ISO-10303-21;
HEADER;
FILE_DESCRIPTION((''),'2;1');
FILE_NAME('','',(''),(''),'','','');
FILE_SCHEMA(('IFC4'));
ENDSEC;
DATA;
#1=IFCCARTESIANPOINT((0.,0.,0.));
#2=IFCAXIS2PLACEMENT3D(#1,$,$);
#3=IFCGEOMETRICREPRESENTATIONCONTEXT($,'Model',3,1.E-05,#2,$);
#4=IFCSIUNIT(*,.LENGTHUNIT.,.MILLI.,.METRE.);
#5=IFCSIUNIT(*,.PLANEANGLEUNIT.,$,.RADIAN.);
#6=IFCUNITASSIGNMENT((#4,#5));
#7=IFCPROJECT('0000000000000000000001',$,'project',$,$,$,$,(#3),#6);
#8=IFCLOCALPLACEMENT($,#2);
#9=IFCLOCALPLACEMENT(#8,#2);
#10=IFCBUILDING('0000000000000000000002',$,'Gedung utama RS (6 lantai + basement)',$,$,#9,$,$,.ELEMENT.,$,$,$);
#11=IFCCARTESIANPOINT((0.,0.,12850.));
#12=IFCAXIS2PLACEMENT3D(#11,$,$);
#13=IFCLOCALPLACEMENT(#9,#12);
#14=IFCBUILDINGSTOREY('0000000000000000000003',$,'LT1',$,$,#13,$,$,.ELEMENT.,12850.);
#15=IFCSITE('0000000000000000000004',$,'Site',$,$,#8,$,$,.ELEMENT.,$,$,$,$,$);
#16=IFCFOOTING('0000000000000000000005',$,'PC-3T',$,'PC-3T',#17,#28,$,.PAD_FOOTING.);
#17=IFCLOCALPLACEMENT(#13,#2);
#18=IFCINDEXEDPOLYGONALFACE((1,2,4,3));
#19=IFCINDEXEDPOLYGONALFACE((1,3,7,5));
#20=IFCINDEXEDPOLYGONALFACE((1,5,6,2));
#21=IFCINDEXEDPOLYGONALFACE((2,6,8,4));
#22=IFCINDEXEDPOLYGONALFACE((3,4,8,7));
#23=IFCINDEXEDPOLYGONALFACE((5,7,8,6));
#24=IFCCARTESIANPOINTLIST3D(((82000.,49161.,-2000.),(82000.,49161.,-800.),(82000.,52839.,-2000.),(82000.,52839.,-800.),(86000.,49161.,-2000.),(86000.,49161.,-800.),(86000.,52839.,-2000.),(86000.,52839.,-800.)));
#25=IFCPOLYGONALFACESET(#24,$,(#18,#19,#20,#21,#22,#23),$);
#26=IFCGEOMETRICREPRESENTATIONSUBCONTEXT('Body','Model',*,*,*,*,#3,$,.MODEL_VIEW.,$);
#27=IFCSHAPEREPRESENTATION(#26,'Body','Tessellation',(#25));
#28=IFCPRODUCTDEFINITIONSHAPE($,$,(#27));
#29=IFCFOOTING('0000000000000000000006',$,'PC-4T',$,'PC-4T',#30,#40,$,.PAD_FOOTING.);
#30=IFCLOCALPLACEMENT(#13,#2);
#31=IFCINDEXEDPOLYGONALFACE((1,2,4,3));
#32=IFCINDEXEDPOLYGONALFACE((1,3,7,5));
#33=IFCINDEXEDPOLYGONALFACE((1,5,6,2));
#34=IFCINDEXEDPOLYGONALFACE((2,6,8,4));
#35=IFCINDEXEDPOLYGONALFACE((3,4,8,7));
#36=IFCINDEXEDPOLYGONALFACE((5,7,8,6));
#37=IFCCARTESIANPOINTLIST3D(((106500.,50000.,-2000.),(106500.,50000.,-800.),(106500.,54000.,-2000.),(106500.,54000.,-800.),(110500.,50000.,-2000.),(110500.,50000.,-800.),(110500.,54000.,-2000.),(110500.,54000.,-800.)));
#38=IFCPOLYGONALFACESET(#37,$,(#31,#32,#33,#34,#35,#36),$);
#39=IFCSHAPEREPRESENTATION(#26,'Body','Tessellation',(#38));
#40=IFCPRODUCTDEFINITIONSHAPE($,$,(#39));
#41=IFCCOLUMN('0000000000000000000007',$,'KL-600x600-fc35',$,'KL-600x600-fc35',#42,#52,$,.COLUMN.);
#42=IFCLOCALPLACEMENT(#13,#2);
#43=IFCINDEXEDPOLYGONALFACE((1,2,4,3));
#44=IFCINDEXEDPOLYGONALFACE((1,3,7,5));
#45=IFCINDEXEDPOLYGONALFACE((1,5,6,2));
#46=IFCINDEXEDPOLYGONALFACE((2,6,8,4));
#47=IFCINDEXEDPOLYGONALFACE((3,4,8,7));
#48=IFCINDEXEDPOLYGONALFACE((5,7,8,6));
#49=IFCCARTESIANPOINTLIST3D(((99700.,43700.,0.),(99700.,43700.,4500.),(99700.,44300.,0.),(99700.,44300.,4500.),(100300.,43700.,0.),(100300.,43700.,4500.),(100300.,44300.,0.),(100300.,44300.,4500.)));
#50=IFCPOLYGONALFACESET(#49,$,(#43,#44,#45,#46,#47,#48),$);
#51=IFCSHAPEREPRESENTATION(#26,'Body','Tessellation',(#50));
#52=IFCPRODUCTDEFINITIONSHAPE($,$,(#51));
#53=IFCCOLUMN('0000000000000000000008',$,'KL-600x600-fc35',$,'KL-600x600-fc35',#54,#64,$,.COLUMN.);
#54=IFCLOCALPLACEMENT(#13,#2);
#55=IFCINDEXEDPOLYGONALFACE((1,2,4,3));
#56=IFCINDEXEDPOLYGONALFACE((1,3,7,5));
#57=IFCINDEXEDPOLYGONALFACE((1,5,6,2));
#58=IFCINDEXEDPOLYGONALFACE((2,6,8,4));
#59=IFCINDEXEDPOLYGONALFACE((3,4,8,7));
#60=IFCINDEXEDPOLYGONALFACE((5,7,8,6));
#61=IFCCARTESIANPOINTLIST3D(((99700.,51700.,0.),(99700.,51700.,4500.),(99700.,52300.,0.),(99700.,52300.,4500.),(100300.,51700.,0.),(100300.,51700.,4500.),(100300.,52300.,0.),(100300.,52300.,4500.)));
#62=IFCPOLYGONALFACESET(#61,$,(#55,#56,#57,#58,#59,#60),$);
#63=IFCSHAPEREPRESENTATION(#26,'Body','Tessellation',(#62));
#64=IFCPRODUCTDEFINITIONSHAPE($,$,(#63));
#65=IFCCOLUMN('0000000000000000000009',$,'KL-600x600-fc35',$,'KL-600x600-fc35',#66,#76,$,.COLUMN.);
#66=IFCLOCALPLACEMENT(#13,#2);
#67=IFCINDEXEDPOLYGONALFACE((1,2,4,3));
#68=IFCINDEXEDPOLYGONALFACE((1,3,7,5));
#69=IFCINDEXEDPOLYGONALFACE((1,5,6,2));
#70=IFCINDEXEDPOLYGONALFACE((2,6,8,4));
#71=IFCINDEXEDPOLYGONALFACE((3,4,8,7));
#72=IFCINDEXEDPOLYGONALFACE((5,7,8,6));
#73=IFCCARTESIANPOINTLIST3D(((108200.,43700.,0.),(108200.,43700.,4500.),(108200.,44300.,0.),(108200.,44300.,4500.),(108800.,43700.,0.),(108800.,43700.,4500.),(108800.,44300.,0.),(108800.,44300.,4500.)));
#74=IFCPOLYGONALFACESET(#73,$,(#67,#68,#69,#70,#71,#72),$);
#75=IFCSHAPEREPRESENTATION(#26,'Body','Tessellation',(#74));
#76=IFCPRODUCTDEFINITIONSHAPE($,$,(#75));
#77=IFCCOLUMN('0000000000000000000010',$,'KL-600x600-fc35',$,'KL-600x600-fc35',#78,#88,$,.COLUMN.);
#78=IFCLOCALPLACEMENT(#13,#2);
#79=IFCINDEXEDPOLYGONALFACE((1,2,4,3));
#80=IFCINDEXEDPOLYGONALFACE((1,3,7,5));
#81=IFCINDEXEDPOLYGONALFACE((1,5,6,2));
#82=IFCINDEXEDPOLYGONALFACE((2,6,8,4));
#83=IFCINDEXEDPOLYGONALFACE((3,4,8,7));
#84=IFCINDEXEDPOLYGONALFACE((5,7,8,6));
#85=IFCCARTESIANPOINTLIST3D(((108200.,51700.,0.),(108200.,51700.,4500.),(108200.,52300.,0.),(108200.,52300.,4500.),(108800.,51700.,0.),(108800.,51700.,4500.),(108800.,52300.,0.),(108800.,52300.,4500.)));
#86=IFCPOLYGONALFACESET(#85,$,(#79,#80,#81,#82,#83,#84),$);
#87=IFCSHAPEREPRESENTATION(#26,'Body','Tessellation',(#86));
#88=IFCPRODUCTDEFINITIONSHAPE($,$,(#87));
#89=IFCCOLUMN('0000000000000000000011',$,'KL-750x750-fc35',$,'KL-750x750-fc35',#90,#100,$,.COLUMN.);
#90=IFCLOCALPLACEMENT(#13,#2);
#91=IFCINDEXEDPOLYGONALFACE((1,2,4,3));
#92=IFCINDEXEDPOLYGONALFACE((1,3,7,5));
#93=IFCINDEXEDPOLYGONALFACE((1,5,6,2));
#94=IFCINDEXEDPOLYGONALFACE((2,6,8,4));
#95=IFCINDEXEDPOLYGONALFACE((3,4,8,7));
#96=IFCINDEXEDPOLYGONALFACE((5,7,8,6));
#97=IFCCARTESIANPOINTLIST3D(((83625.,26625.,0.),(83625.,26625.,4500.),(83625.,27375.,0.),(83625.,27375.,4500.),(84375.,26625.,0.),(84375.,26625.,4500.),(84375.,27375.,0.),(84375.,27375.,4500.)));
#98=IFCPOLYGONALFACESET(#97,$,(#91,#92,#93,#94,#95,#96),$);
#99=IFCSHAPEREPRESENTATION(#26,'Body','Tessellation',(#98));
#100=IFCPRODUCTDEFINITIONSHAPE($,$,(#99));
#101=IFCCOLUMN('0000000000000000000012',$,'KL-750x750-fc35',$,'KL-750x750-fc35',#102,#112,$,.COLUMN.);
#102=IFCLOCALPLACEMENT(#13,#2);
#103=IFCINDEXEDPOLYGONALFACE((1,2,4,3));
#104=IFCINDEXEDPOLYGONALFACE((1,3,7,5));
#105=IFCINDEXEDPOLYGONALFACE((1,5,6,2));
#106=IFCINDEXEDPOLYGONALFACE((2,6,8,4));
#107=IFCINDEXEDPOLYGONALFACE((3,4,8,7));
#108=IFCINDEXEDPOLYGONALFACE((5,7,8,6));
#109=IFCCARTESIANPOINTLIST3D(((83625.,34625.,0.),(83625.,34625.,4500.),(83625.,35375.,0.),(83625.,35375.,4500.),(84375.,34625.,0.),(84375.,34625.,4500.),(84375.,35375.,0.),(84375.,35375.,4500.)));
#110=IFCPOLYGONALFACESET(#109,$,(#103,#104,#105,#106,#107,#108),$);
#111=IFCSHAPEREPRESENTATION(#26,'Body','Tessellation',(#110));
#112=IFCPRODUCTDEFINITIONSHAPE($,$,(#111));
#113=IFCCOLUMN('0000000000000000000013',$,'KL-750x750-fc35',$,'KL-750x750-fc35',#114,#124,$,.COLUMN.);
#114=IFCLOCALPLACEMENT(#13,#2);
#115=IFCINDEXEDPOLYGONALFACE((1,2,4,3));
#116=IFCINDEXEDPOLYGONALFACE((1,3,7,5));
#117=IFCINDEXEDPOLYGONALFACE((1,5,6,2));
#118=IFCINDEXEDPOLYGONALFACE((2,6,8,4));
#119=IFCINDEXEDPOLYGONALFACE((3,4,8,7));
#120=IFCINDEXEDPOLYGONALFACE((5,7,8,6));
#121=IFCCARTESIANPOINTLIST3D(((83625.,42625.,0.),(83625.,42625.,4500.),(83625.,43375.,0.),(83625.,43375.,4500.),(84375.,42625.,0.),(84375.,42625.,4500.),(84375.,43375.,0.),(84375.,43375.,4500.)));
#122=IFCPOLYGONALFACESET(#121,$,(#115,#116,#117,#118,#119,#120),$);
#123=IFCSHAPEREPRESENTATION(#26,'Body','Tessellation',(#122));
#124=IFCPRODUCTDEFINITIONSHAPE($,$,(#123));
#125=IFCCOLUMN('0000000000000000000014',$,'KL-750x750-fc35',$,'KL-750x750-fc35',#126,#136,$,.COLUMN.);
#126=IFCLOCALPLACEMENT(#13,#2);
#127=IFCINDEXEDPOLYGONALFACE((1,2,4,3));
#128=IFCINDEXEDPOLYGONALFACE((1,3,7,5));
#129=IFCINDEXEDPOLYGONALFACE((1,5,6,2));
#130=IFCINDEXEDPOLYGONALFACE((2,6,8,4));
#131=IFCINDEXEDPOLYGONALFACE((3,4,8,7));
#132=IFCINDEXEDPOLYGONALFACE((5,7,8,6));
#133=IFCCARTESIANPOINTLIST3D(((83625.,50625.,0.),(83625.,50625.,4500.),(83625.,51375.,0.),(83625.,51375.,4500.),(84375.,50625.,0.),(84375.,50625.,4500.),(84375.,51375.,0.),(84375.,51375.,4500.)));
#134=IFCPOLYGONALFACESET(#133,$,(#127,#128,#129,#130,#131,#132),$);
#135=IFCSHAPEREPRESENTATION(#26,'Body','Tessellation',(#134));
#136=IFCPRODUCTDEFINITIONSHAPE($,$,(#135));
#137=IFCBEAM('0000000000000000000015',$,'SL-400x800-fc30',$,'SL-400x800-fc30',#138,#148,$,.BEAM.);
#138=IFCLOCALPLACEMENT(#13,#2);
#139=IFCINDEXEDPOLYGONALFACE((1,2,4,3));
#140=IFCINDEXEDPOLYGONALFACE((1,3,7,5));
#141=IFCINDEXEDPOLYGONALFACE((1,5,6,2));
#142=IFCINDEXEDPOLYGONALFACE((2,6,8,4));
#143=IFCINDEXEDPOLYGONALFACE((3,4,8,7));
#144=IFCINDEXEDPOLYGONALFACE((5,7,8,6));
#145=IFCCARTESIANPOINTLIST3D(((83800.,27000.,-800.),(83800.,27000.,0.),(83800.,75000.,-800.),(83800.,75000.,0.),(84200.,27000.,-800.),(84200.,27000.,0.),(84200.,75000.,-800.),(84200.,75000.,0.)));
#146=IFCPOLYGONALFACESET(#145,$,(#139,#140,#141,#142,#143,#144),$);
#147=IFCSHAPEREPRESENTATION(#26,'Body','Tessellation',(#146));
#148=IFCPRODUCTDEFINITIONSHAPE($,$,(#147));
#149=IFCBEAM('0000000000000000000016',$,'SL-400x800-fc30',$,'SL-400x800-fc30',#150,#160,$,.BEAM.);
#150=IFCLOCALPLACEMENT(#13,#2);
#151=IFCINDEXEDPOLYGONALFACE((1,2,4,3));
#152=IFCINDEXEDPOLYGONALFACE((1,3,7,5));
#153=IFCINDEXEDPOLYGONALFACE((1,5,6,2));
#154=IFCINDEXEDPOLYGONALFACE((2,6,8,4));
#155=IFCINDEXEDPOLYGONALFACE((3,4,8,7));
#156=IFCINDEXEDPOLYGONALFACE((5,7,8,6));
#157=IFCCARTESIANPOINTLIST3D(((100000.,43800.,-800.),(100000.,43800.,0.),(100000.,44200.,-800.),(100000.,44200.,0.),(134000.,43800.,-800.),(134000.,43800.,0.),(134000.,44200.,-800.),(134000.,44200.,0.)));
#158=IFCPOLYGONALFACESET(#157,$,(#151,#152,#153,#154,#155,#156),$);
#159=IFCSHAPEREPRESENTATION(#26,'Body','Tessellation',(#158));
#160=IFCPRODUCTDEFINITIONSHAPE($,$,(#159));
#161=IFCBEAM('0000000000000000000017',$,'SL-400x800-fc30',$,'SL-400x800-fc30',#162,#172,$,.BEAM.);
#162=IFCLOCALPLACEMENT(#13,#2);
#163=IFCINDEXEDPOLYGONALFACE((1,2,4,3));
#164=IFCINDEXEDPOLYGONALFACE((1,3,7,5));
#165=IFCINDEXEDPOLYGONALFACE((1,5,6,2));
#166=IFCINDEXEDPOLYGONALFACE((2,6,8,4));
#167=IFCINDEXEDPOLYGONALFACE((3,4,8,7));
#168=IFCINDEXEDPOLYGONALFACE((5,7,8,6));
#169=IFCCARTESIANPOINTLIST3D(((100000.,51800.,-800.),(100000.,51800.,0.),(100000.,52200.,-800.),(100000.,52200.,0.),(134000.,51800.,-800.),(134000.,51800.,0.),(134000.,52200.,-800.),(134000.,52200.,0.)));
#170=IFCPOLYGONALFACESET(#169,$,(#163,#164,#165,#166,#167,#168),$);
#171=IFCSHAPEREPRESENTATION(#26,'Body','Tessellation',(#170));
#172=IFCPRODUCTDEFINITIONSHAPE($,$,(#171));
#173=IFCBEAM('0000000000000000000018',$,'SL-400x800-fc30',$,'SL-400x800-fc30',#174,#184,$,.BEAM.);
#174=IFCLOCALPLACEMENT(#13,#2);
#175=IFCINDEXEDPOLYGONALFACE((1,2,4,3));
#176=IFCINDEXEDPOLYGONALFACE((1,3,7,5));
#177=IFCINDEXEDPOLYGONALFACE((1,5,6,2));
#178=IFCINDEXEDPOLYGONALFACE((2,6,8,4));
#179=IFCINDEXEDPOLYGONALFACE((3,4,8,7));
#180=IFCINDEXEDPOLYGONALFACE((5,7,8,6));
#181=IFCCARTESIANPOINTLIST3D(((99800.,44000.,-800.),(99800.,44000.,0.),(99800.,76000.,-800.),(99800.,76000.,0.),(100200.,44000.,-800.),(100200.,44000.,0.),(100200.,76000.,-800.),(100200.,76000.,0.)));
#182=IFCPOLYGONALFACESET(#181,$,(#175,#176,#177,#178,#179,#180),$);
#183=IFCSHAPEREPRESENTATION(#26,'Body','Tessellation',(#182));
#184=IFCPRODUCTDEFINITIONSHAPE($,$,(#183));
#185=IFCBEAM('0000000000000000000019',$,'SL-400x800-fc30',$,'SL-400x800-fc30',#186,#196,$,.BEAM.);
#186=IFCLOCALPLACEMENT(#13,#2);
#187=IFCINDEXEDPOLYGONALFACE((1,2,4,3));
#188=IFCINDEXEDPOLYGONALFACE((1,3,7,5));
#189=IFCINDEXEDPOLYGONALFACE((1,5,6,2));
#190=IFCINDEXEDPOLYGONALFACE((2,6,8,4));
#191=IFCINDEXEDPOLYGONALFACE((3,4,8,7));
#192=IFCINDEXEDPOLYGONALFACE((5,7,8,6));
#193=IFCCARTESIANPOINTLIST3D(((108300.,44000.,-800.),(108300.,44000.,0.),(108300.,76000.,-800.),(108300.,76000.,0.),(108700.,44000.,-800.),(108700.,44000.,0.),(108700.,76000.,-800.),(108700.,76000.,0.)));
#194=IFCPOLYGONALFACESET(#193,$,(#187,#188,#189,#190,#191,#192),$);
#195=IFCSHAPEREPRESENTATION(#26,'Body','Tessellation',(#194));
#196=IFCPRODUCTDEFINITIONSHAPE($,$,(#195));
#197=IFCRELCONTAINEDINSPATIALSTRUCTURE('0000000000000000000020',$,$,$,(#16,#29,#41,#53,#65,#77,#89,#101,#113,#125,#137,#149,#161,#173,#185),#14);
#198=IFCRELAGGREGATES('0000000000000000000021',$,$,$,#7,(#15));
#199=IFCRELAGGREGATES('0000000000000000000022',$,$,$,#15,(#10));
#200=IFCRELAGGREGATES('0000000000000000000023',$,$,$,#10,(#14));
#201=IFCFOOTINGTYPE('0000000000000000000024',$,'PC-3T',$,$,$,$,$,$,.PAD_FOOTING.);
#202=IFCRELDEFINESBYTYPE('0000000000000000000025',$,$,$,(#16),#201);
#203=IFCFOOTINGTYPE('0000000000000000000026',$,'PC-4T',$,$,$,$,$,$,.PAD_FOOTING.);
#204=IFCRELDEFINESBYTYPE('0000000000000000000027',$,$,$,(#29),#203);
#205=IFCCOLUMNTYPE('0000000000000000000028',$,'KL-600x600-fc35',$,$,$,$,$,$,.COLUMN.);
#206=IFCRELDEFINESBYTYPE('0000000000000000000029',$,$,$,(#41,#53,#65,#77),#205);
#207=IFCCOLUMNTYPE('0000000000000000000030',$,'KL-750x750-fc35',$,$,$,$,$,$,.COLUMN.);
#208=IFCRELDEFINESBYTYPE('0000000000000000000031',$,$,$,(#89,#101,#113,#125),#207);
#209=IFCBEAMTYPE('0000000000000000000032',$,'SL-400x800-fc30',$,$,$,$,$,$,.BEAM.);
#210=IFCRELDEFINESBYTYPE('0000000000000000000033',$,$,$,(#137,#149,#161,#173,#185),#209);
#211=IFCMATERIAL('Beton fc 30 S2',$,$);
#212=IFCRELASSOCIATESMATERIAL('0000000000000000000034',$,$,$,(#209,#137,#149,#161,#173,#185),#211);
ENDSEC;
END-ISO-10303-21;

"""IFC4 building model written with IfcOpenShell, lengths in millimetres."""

from ifc_helpers import new_model, si_unit, frame, origin, origin_2d, place, context, subcontext, project, spatial, rectangle, extrude, material, material_profile, profile_set, profile_usage, type_object, element, save


model = new_model("IFC4")

# Units and contexts
model_context = context("Model", 3, precision=1e-05, world=origin())
body_context = subcontext(model_context, "Body", "Model", "MODEL_VIEW")
ifc_project = project(units=[si_unit("LENGTHUNIT", "METRE", prefix="MILLI"), si_unit("PLANEANGLEUNIT", "RADIAN")], contexts=[model_context])

# Site, building, storey
site_placement = place(None, origin())
site = spatial("IfcSite", under=ifc_project, at=site_placement, Name="Site", CompositionType="ELEMENT")
building_placement = place(site_placement, origin())
building = spatial("IfcBuilding", under=site, at=building_placement, Name="Gedung utama RS (6 lantai + basement)", CompositionType="ELEMENT")
storey_placement = place(building_placement, frame((0.0, 0.0, 12850.0)))
storey = spatial("IfcBuildingStorey", under=building, at=storey_placement, Name="LT1", CompositionType="ELEMENT", Elevation=12850.0)

# Footings
ifc_material_profile_1 = material_profile(None, rectangle(XDim=4000.0, YDim=3678.0, at=origin_2d()), Name="PC-3T")
ifc_profile_set_1 = profile_set([ifc_material_profile_1], Name="PC-3T")
ifc_profile_usage_1 = profile_usage(ifc_profile_set_1, cardinal=5)
footing_type_1 = type_object("IfcFootingType", Name="PC-3T", PredefinedType="PAD_FOOTING", material=ifc_profile_set_1)
for number, where, z_axis, x_axis, name in (
    (1, (84000.0, 51000.0, -2000.0), (0.0, 0.0, 1.0), (1.0, 0.0, 0.0), "PC-3T"),
):
    element("IfcFooting", number, at=place(storey_placement, frame(where, z_axis=z_axis, x_axis=x_axis)), inside=storey, type_object=footing_type_1, material=ifc_profile_usage_1, Name=name, ObjectType="PC-3T", PredefinedType="PAD_FOOTING", context=body_context, shape_type="SweptSolid", body=[
        extrude(rectangle(XDim=4000.0, YDim=3678.0, at=origin_2d()), origin(), (0.0, 0.0, 1.0), 1200.0),
    ])
ifc_material_profile_2 = material_profile(None, rectangle(XDim=4000.0, YDim=4000.0, at=origin_2d()), Name="PC-4T")
ifc_profile_set_2 = profile_set([ifc_material_profile_2], Name="PC-4T")
ifc_profile_usage_2 = profile_usage(ifc_profile_set_2, cardinal=5)
footing_type_2 = type_object("IfcFootingType", Name="PC-4T", PredefinedType="PAD_FOOTING", material=ifc_profile_set_2)
footing_placement = place(storey_placement, frame((108500.0, 52000.0, -2000.0), z_axis=(0.0, 0.0, 1.0), x_axis=(1.0, 0.0, 0.0)))
element("IfcFooting", 2, at=footing_placement, inside=storey, type_object=footing_type_2, material=ifc_profile_usage_2, Name="PC-4T", ObjectType="PC-4T", PredefinedType="PAD_FOOTING", context=body_context, shape_type="SweptSolid", body=[
    extrude(rectangle(XDim=4000.0, YDim=4000.0, at=origin_2d()), origin(), (0.0, 0.0, 1.0), 1200.0),
])

# Columns
ifc_material_profile_3 = material_profile(None, rectangle(XDim=600.0, YDim=600.0, at=origin_2d()), Name="KL-600x600-fc35")
ifc_profile_set_3 = profile_set([ifc_material_profile_3], Name="KL-600x600-fc35")
ifc_profile_usage_3 = profile_usage(ifc_profile_set_3, cardinal=5)
column_type_1 = type_object("IfcColumnType", Name="KL-600x600-fc35", PredefinedType="COLUMN", material=ifc_profile_set_3)
for number, where, z_axis, x_axis, name in (
    (3, (100000.0, 44000.0, 0.0), (0.0, 0.0, 1.0), (1.0, 0.0, 0.0), "KL-600x600-fc35"),
    (4, (100000.0, 52000.0, 0.0), (0.0, 0.0, 1.0), (1.0, 0.0, 0.0), "KL-600x600-fc35"),
    (5, (108500.0, 44000.0, 0.0), (0.0, 0.0, 1.0), (1.0, 0.0, 0.0), "KL-600x600-fc35"),
    (6, (108500.0, 52000.0, 0.0), (0.0, 0.0, 1.0), (1.0, 0.0, 0.0), "KL-600x600-fc35"),
):
    element("IfcColumn", number, at=place(storey_placement, frame(where, z_axis=z_axis, x_axis=x_axis)), inside=storey, type_object=column_type_1, material=ifc_profile_usage_3, Name=name, ObjectType="KL-600x600-fc35", PredefinedType="COLUMN", context=body_context, shape_type="SweptSolid", body=[
        extrude(rectangle(XDim=600.0, YDim=600.0, at=origin_2d()), origin(), (0.0, 0.0, 1.0), 4500.0),
    ])
ifc_material_profile_4 = material_profile(None, rectangle(XDim=750.0, YDim=750.0, at=origin_2d()), Name="KL-750x750-fc35")
ifc_profile_set_4 = profile_set([ifc_material_profile_4], Name="KL-750x750-fc35")
ifc_profile_usage_4 = profile_usage(ifc_profile_set_4, cardinal=5)
column_type_2 = type_object("IfcColumnType", Name="KL-750x750-fc35", PredefinedType="COLUMN", material=ifc_profile_set_4)
for number, where, z_axis, x_axis, name in (
    (7, (84000.0, 27000.0, 0.0), (0.0, 0.0, 1.0), (1.0, 0.0, 0.0), "KL-750x750-fc35"),
    (8, (84000.0, 35000.0, 0.0), (0.0, 0.0, 1.0), (1.0, 0.0, 0.0), "KL-750x750-fc35"),
    (9, (84000.0, 43000.0, 0.0), (0.0, 0.0, 1.0), (1.0, 0.0, 0.0), "KL-750x750-fc35"),
    (10, (84000.0, 51000.0, 0.0), (0.0, 0.0, 1.0), (1.0, 0.0, 0.0), "KL-750x750-fc35"),
):
    element("IfcColumn", number, at=place(storey_placement, frame(where, z_axis=z_axis, x_axis=x_axis)), inside=storey, type_object=column_type_2, material=ifc_profile_usage_4, Name=name, ObjectType="KL-750x750-fc35", PredefinedType="COLUMN", context=body_context, shape_type="SweptSolid", body=[
        extrude(rectangle(XDim=750.0, YDim=750.0, at=origin_2d()), origin(), (0.0, 0.0, 1.0), 4500.0),
    ])

# Beams
ifc_material = material(Name="Beton fc 30 S2")
ifc_material_profile_5 = material_profile(ifc_material, rectangle(XDim=400.0, YDim=800.0, at=origin_2d()), Name="SL-400x800-fc30")
ifc_profile_set_5 = profile_set([ifc_material_profile_5], Name="SL-400x800-fc30")
ifc_profile_usage_5 = profile_usage(ifc_profile_set_5, cardinal=8)
beam_type = type_object("IfcBeamType", Name="SL-400x800-fc30", PredefinedType="BEAM", material=ifc_profile_set_5)
beam_placement = place(storey_placement, frame((84000.0, 27000.0, -400.0)))
element("IfcBeam", 11, at=beam_placement, inside=storey, type_object=beam_type, material=ifc_profile_usage_5, Name="SL-400x800-fc30", ObjectType="SL-400x800-fc30", PredefinedType="BEAM", context=body_context, shape_type="SweptSolid", body=[
    extrude(rectangle(XDim=400.0, YDim=800.0, at=origin_2d()), frame((0.0, 0.0, 0.0), z_axis=(0.0, 1.0, 0.0), x_axis=(-1.0, 0.0, 0.0)), (0.0, 0.0, 1.0), 48000.0),
])
for number, where, name in (
    (12, (100000.0, 44000.0, -400.0), "SL-400x800-fc30"),
    (13, (100000.0, 52000.0, -400.0), "SL-400x800-fc30"),
):
    element("IfcBeam", number, at=place(storey_placement, frame(where)), inside=storey, type_object=beam_type, material=ifc_profile_usage_5, Name=name, ObjectType="SL-400x800-fc30", PredefinedType="BEAM", context=body_context, shape_type="SweptSolid", body=[
        extrude(rectangle(XDim=400.0, YDim=800.0, at=origin_2d()), frame((0.0, 0.0, 0.0), z_axis=(1.0, 0.0, 0.0), x_axis=(0.0, 1.0, 0.0)), (0.0, 0.0, 1.0), 34000.0),
    ])
for number, where, name in (
    (14, (100000.0, 44000.0, -400.0), "SL-400x800-fc30"),
    (15, (108500.0, 44000.0, -400.0), "SL-400x800-fc30"),
):
    element("IfcBeam", number, at=place(storey_placement, frame(where)), inside=storey, type_object=beam_type, material=ifc_profile_usage_5, Name=name, ObjectType="SL-400x800-fc30", PredefinedType="BEAM", context=body_context, shape_type="SweptSolid", body=[
        extrude(rectangle(XDim=400.0, YDim=800.0, at=origin_2d()), frame((0.0, 0.0, 0.0), z_axis=(0.0, 1.0, 0.0), x_axis=(-1.0, 0.0, 0.0)), (0.0, 0.0, 1.0), 32000.0),
    ])

save(model, "model.ifc")
